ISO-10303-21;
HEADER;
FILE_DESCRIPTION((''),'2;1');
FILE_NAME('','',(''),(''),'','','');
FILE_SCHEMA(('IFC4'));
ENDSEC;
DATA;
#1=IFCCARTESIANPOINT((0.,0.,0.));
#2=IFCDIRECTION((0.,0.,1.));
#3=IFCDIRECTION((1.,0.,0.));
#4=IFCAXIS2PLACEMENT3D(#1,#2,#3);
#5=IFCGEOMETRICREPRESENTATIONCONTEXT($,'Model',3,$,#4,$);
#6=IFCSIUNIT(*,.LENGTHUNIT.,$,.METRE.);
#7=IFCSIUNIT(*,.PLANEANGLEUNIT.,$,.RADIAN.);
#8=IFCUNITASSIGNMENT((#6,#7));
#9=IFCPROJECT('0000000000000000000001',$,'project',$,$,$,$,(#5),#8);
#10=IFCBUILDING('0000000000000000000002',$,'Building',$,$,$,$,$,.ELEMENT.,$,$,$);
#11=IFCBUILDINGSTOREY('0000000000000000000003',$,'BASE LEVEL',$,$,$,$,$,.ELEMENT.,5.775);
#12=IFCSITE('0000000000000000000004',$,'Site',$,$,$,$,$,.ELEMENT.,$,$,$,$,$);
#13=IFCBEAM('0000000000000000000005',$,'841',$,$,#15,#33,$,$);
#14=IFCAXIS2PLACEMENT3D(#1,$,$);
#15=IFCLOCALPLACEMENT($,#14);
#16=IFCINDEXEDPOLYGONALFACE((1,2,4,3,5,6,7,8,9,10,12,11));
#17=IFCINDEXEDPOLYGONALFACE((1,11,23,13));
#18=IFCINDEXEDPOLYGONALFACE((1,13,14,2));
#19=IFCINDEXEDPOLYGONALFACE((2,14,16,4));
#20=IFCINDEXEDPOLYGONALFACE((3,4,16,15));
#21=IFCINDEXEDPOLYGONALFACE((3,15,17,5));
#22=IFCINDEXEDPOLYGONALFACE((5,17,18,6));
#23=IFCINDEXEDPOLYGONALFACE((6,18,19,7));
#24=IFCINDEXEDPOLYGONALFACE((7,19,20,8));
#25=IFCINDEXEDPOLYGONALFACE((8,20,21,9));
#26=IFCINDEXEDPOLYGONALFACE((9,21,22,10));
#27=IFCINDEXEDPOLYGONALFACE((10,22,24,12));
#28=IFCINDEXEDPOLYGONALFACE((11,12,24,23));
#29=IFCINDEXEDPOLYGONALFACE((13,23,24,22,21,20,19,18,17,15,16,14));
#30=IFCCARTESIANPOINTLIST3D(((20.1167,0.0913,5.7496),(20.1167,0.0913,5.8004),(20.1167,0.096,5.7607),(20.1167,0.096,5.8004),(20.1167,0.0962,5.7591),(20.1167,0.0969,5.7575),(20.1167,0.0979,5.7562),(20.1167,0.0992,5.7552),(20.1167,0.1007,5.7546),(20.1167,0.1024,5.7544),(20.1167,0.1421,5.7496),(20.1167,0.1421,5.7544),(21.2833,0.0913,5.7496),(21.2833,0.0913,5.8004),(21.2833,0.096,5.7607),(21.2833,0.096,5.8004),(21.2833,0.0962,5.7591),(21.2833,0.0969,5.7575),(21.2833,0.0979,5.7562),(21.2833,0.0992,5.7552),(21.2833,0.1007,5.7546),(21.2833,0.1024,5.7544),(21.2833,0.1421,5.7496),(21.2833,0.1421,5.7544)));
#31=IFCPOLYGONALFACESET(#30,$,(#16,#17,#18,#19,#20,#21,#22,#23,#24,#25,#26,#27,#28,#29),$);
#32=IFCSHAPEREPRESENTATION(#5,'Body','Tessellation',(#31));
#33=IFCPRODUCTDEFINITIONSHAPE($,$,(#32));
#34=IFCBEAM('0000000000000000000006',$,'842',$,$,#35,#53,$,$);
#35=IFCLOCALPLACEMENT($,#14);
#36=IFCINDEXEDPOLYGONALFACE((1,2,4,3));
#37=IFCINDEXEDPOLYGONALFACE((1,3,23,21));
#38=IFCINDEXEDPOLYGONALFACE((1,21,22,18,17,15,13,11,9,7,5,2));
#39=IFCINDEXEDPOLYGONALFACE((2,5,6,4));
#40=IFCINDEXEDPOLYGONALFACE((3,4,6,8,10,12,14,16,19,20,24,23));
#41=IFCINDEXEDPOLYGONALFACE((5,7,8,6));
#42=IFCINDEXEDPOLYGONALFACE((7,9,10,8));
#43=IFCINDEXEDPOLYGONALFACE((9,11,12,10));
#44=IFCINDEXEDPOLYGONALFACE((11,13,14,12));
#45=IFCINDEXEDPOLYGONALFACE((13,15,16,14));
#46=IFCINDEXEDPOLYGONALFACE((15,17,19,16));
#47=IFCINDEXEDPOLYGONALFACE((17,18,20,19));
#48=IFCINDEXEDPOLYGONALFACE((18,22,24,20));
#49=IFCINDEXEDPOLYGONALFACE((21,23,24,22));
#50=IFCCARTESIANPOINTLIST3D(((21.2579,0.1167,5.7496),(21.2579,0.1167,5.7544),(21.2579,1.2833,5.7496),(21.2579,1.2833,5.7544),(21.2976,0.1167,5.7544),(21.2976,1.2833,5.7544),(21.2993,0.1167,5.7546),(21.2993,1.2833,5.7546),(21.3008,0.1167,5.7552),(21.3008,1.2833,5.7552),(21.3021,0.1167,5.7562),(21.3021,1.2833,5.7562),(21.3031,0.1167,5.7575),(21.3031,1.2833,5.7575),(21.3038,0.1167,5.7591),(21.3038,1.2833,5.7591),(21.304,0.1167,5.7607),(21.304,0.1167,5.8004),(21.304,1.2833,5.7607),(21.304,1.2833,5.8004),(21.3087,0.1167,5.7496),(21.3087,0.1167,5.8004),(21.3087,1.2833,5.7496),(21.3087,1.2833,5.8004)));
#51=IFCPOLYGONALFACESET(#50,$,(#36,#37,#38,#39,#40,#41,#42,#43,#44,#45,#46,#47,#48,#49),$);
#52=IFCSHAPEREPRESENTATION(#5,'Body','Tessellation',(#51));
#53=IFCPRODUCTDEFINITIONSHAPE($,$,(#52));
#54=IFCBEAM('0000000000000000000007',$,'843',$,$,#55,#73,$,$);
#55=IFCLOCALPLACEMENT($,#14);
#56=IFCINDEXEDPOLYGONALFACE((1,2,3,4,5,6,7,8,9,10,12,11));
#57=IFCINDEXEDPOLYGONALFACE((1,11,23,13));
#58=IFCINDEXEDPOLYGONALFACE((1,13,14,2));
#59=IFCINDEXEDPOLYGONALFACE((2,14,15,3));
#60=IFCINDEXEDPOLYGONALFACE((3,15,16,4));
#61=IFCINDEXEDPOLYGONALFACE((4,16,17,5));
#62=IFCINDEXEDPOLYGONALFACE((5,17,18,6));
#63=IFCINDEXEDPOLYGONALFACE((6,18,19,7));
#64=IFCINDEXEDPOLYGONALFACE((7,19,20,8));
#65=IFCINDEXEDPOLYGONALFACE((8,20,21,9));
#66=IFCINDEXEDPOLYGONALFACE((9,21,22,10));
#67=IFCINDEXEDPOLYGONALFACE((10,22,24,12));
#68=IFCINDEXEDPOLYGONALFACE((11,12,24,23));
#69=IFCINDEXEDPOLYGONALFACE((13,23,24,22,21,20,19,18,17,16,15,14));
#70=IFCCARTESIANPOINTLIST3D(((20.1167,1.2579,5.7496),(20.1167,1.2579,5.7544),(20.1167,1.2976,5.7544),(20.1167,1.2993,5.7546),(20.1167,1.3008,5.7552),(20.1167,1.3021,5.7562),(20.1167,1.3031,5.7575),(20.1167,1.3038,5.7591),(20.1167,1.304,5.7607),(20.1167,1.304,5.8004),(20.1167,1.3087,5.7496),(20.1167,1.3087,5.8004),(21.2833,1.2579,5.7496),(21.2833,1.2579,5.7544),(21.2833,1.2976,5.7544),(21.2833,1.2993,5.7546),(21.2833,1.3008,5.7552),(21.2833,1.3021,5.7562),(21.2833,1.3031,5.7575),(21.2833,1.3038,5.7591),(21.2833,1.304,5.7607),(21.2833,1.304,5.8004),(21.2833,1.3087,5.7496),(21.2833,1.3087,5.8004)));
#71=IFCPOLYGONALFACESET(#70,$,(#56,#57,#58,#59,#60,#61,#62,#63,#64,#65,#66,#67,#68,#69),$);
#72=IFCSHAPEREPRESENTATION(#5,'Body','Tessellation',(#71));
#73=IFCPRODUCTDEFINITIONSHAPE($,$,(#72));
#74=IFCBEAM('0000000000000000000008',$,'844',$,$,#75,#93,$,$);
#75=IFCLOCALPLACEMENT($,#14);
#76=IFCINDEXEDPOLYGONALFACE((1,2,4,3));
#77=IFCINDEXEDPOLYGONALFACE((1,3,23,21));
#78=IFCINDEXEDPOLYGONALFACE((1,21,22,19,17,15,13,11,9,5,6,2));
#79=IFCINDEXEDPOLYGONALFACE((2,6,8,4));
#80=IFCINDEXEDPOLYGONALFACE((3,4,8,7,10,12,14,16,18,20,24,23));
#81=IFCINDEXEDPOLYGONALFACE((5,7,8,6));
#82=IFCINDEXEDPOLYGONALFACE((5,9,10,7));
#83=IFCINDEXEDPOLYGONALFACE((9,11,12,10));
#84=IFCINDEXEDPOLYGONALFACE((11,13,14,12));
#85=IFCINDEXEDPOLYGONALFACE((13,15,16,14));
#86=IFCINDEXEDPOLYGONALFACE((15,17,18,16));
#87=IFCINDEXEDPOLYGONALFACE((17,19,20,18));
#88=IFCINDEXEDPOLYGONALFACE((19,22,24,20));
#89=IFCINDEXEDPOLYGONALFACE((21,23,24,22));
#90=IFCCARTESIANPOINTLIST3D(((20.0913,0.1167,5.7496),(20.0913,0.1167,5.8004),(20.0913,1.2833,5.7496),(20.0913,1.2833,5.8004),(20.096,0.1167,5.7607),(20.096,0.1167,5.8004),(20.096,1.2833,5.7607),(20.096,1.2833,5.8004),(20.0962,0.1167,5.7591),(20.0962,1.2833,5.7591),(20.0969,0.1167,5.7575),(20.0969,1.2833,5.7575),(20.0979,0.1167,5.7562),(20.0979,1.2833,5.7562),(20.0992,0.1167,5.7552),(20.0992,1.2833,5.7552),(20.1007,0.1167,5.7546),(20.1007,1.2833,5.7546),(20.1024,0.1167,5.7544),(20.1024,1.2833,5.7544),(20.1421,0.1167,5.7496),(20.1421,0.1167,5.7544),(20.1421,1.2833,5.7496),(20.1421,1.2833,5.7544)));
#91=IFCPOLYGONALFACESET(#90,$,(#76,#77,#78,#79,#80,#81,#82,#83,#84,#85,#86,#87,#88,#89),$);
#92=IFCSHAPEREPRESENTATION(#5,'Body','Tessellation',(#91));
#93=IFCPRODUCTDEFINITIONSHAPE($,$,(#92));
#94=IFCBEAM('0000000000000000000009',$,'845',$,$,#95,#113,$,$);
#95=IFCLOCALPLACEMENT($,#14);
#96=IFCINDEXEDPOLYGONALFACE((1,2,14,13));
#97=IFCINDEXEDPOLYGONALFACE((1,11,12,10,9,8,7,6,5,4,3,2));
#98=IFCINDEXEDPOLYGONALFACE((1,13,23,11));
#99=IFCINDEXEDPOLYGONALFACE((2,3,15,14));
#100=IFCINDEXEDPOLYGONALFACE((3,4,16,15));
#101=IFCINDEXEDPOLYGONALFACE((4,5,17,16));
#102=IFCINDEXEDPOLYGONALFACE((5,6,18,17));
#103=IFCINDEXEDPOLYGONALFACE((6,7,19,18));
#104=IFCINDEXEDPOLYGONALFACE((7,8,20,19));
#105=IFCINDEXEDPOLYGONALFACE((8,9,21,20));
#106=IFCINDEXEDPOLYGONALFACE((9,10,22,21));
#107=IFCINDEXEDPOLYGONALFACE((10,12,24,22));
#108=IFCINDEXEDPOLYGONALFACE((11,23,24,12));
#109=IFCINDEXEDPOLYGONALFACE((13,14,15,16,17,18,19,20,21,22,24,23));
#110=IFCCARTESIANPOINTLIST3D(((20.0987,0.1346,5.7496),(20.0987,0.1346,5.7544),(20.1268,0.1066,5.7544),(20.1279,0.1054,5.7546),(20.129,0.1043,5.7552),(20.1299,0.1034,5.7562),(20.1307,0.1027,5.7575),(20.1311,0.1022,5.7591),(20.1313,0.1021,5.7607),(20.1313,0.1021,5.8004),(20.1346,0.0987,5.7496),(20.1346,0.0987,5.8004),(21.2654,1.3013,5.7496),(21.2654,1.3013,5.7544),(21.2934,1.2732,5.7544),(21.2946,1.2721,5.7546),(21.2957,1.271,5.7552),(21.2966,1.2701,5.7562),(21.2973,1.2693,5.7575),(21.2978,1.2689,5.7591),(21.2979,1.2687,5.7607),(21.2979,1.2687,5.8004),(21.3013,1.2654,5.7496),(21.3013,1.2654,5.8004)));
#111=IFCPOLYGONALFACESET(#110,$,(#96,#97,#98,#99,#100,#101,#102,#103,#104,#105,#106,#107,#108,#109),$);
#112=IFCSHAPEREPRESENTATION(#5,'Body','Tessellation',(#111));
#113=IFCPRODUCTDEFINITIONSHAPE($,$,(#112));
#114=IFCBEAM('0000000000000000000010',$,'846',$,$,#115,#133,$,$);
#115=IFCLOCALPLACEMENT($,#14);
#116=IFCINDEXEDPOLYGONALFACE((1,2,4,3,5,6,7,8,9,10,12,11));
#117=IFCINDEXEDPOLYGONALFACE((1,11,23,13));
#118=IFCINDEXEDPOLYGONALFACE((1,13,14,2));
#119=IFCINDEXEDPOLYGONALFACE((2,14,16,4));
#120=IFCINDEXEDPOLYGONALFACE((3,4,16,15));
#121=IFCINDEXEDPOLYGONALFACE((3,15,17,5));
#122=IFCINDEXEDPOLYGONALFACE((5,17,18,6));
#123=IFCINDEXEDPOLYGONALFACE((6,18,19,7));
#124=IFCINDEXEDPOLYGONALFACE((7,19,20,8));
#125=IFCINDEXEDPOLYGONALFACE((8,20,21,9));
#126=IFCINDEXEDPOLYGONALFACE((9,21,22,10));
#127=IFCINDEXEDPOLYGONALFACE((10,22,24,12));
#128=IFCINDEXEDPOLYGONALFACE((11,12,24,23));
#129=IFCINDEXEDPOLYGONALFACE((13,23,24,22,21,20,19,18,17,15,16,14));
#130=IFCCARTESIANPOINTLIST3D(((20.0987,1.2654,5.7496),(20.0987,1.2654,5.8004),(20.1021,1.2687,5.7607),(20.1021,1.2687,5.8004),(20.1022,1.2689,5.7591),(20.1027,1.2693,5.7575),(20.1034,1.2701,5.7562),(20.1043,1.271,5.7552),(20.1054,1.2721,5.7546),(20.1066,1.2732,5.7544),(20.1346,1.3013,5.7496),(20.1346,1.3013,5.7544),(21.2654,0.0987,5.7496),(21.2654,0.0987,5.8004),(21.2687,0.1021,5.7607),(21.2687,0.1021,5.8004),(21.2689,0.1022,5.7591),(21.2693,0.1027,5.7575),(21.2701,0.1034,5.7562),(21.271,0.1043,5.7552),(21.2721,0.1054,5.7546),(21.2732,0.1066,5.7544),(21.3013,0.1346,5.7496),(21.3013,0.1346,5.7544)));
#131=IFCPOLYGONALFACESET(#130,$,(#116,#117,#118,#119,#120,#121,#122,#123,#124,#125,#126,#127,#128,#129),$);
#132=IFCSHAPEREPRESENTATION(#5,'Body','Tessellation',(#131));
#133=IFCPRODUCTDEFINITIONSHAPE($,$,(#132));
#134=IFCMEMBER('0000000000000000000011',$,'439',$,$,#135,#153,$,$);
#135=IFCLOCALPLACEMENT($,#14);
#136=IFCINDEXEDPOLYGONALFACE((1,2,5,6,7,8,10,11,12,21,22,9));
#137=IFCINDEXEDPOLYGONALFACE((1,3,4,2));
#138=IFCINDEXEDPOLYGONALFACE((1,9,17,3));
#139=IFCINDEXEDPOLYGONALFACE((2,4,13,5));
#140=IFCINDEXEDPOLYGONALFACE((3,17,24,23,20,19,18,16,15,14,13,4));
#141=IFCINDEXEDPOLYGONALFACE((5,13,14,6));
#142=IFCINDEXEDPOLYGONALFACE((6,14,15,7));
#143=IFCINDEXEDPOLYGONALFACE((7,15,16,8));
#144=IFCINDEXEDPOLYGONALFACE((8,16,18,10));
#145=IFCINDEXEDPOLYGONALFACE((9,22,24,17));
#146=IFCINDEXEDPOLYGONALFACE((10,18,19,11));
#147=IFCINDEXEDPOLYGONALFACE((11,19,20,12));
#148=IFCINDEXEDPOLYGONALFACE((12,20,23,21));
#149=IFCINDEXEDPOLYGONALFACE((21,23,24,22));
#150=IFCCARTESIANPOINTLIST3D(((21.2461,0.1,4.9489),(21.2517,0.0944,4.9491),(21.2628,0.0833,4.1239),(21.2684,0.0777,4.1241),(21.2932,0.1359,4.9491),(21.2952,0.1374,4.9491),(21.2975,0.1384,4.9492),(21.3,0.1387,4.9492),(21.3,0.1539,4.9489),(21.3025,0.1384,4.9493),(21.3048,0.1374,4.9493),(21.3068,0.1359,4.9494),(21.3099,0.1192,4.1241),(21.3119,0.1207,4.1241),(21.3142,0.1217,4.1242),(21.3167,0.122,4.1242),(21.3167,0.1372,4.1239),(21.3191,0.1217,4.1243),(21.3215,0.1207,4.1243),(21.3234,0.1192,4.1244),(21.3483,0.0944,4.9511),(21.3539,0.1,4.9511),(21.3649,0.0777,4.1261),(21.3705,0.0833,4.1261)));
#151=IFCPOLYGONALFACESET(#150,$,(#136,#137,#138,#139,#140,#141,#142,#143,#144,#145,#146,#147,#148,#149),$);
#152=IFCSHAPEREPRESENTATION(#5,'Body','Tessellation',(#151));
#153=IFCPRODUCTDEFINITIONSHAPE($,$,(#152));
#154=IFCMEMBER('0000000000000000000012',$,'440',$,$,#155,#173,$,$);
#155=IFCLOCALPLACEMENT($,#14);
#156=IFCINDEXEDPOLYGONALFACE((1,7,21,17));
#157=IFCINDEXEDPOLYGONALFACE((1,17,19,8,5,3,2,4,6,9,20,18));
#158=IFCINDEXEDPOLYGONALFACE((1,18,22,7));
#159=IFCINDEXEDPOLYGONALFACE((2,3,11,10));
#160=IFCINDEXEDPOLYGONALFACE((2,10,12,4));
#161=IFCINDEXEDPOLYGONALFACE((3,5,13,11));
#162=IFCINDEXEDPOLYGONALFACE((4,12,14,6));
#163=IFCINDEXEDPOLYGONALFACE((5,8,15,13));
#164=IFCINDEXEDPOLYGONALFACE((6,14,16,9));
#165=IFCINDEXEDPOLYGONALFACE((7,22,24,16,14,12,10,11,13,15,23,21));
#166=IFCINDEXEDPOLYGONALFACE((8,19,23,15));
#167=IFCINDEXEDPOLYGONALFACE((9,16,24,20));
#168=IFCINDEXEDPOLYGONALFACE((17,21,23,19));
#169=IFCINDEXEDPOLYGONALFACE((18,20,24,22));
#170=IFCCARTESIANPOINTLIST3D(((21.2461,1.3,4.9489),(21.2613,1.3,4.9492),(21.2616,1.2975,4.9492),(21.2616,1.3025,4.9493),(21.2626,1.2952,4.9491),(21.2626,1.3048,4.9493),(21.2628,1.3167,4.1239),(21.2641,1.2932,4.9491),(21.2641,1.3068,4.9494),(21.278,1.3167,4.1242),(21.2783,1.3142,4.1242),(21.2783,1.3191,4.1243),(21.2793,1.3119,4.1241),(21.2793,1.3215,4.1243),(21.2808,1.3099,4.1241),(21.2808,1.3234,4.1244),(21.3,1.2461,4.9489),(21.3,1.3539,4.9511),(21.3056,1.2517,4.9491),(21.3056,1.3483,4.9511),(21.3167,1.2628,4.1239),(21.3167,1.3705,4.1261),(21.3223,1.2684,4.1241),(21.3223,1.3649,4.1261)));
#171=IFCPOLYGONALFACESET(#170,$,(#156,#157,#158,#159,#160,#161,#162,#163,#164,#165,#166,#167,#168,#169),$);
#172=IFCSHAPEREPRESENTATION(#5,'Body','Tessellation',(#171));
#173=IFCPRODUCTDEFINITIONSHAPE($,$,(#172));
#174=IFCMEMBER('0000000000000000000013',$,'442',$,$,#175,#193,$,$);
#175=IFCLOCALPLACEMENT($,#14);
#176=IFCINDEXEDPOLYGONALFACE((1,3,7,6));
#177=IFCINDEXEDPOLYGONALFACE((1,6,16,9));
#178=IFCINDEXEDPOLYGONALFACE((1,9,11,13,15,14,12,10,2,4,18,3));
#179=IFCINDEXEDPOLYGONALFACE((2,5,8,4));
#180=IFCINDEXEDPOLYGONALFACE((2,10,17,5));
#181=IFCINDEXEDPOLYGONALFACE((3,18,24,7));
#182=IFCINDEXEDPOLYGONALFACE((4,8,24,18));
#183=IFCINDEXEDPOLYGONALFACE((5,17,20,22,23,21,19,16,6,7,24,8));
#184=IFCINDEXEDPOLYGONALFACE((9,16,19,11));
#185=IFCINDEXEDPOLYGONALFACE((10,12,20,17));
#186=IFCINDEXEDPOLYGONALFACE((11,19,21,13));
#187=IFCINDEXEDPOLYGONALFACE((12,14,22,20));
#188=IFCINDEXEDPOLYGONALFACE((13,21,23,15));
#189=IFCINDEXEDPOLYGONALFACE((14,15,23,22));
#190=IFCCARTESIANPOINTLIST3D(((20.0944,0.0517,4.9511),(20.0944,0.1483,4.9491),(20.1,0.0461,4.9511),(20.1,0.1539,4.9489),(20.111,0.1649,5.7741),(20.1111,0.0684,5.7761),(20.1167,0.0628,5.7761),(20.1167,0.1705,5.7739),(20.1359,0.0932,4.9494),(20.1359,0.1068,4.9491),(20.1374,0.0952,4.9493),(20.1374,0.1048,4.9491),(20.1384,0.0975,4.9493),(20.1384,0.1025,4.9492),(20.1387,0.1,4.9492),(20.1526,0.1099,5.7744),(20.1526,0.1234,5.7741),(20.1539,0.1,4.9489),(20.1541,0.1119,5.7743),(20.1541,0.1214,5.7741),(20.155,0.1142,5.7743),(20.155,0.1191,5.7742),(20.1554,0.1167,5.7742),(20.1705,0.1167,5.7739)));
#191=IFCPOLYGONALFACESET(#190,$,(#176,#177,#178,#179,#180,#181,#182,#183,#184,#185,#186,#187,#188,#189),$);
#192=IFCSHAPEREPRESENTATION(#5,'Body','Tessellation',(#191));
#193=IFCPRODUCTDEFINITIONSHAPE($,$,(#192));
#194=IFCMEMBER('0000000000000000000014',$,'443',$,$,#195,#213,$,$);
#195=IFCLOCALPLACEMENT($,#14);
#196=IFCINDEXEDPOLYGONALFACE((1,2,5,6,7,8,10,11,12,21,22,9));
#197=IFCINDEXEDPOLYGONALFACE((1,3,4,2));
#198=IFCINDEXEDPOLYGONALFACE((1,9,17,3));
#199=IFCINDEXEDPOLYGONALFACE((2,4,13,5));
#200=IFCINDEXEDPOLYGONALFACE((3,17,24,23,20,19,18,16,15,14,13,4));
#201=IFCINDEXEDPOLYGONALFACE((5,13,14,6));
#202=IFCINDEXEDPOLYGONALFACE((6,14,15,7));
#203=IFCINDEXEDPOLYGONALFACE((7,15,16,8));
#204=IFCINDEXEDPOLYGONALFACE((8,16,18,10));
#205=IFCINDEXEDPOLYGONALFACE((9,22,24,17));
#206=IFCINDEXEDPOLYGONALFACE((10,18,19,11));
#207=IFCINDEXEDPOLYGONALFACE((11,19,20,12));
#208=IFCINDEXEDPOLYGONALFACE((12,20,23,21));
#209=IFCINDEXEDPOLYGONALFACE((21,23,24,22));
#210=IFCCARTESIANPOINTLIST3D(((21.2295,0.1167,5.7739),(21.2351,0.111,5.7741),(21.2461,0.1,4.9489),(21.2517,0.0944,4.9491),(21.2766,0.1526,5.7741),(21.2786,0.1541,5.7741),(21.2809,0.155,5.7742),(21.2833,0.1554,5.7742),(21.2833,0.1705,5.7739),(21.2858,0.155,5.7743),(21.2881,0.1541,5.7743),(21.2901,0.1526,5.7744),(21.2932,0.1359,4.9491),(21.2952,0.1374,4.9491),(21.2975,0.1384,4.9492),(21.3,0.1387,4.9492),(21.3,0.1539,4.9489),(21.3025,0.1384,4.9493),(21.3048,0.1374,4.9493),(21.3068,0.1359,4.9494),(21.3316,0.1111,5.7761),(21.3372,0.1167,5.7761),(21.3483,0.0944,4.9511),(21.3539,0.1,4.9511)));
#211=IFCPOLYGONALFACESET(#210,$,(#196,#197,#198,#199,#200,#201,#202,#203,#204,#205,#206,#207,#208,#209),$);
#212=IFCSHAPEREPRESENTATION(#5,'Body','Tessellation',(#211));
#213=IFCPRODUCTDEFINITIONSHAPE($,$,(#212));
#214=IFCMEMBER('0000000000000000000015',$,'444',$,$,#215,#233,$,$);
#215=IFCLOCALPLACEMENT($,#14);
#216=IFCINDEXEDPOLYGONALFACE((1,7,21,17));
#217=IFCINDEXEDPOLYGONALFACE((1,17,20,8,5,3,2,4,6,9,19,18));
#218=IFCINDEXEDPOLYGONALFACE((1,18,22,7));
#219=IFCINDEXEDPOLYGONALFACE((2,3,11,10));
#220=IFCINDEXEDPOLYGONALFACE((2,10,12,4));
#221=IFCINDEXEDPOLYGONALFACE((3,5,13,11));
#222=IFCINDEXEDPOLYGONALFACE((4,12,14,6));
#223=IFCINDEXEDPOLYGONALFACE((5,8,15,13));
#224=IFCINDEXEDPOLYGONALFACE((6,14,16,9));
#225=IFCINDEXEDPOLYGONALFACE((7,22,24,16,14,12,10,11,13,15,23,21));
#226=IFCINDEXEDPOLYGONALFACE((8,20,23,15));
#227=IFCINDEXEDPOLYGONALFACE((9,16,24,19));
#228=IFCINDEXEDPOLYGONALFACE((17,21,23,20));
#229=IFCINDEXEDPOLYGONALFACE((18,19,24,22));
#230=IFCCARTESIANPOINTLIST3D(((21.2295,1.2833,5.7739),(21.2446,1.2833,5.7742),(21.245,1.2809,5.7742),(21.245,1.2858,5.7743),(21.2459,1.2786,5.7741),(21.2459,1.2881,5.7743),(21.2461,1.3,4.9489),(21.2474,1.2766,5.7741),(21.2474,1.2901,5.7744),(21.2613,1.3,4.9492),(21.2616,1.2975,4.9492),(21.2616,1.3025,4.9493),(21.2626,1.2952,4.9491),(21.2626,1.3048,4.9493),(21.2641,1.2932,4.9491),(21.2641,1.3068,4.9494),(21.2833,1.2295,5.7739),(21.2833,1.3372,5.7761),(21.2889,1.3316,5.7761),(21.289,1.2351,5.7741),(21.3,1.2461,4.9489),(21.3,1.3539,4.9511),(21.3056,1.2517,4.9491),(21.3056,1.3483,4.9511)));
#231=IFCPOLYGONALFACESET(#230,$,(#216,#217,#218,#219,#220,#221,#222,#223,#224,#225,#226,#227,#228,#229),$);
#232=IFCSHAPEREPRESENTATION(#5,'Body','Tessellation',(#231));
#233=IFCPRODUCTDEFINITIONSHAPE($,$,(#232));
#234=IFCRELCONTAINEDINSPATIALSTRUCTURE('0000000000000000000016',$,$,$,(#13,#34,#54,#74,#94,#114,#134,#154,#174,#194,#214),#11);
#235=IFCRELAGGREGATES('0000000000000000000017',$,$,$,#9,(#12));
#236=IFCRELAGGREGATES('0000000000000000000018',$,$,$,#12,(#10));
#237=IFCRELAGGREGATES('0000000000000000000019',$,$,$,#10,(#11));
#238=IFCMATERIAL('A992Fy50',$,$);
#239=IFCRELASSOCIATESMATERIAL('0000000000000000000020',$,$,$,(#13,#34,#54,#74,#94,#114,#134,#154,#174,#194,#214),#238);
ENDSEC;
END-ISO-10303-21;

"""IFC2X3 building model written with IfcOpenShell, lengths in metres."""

from ifc_helpers import new_model, si_unit, frame, origin_with_axes, origin_2d_with_axis, place, context, project, spatial, l_section, extrude, material, element, save


model = new_model("IFC2X3")

# Units and contexts
model_context = context("Model", 3, world=origin_with_axes())
ifc_project = project(units=[si_unit("LENGTHUNIT", "METRE"), si_unit("PLANEANGLEUNIT", "RADIAN")], contexts=[model_context])

# Site, building, storey
site = spatial("IfcSite", under=ifc_project, Name="Site", CompositionType="ELEMENT")
building = spatial("IfcBuilding", under=site, Name="Building", CompositionType="ELEMENT")
storey = spatial("IfcBuildingStorey", under=building, Name="BASE LEVEL", CompositionType="ELEMENT", Elevation=5.775)

# Beams
ifc_material = material(Name="A992Fy50")
for number, where, z_axis, x_axis, name in (
    (1, (20.1167, 0.1167, 5.775), (1.0, 0.0, 0.0), (0.0, 1.0, 0.0), "841"),
    (2, (21.2833, 0.1167, 5.775), (0.0, 1.0, 0.0), (-1.0, 0.0, 0.0), "842"),
    (3, (21.2833, 1.2833, 5.775), (-1.0, 0.0, 0.0), (0.0, -1.0, 0.0), "843"),
    (4, (20.1167, 1.2833, 5.775), (0.0, -1.0, 0.0), (1.0, 0.0, 0.0), "844"),
):
    element("IfcBeam", number, at=place(None, frame(where, z_axis=z_axis, x_axis=x_axis)), inside=storey, material=ifc_material, Name=name, context=model_context, shape_type="SweptSolid", body=[
        extrude(l_section(Depth=0.0508, Width=0.0508, Thickness=0.0048, FilletRadius=0.0063, at=origin_2d_with_axis()), origin_with_axes(), (0.0, 0.0, 1.0), 1.1667),
    ])
for number, where, z_axis, x_axis, name in (
    (5, (20.1167, 0.1167, 5.775), (0.707107, 0.707107, 0.0), (-0.707107, 0.707107, 0.0), "845"),
    (6, (20.1167, 1.2833, 5.775), (0.707107, -0.707107, 0.0), (0.707107, 0.707107, 0.0), "846"),
):
    element("IfcBeam", number, at=place(None, frame(where, z_axis=z_axis, x_axis=x_axis)), inside=storey, material=ifc_material, Name=name, context=model_context, shape_type="SweptSolid", body=[
        extrude(l_section(Depth=0.0508, Width=0.0508, Thickness=0.0048, FilletRadius=0.0063, at=origin_2d_with_axis()), origin_with_axes(), (0.0, 0.0, 1.0), 1.6499),
    ])

# Members
for number, where, z_axis, x_axis, name in (
    (7, (21.3167, 0.0833, 4.125), (-0.020194, 0.020194, 0.999592), (-0.707107, -0.707107, 0.0), "439"),
    (8, (21.3167, 1.3167, 4.125), (-0.020194, -0.020194, 0.999592), (0.707107, -0.707107, 0.0), "440"),
    (9, (20.1, 0.1, 4.95), (0.020194, 0.020194, 0.999592), (-0.707107, 0.707107, 0.0), "442"),
    (10, (21.3, 0.1, 4.95), (-0.020194, 0.020194, 0.999592), (-0.707107, -0.707107, 0.0), "443"),
    (11, (21.3, 1.3, 4.95), (-0.020194, -0.020194, 0.999592), (0.707107, -0.707107, 0.0), "444"),
):
    element("IfcMember", number, at=place(None, frame(where, z_axis=z_axis, x_axis=x_axis)), inside=storey, material=ifc_material, Name=name, context=model_context, shape_type="SweptSolid", body=[
        extrude(l_section(Depth=0.0762, Width=0.0762, Thickness=0.0079, FilletRadius=0.0096, at=origin_2d_with_axis()), origin_with_axes(), (0.0, 0.0, 1.0), 0.8253),
    ])

save(model, "model.ifc")
